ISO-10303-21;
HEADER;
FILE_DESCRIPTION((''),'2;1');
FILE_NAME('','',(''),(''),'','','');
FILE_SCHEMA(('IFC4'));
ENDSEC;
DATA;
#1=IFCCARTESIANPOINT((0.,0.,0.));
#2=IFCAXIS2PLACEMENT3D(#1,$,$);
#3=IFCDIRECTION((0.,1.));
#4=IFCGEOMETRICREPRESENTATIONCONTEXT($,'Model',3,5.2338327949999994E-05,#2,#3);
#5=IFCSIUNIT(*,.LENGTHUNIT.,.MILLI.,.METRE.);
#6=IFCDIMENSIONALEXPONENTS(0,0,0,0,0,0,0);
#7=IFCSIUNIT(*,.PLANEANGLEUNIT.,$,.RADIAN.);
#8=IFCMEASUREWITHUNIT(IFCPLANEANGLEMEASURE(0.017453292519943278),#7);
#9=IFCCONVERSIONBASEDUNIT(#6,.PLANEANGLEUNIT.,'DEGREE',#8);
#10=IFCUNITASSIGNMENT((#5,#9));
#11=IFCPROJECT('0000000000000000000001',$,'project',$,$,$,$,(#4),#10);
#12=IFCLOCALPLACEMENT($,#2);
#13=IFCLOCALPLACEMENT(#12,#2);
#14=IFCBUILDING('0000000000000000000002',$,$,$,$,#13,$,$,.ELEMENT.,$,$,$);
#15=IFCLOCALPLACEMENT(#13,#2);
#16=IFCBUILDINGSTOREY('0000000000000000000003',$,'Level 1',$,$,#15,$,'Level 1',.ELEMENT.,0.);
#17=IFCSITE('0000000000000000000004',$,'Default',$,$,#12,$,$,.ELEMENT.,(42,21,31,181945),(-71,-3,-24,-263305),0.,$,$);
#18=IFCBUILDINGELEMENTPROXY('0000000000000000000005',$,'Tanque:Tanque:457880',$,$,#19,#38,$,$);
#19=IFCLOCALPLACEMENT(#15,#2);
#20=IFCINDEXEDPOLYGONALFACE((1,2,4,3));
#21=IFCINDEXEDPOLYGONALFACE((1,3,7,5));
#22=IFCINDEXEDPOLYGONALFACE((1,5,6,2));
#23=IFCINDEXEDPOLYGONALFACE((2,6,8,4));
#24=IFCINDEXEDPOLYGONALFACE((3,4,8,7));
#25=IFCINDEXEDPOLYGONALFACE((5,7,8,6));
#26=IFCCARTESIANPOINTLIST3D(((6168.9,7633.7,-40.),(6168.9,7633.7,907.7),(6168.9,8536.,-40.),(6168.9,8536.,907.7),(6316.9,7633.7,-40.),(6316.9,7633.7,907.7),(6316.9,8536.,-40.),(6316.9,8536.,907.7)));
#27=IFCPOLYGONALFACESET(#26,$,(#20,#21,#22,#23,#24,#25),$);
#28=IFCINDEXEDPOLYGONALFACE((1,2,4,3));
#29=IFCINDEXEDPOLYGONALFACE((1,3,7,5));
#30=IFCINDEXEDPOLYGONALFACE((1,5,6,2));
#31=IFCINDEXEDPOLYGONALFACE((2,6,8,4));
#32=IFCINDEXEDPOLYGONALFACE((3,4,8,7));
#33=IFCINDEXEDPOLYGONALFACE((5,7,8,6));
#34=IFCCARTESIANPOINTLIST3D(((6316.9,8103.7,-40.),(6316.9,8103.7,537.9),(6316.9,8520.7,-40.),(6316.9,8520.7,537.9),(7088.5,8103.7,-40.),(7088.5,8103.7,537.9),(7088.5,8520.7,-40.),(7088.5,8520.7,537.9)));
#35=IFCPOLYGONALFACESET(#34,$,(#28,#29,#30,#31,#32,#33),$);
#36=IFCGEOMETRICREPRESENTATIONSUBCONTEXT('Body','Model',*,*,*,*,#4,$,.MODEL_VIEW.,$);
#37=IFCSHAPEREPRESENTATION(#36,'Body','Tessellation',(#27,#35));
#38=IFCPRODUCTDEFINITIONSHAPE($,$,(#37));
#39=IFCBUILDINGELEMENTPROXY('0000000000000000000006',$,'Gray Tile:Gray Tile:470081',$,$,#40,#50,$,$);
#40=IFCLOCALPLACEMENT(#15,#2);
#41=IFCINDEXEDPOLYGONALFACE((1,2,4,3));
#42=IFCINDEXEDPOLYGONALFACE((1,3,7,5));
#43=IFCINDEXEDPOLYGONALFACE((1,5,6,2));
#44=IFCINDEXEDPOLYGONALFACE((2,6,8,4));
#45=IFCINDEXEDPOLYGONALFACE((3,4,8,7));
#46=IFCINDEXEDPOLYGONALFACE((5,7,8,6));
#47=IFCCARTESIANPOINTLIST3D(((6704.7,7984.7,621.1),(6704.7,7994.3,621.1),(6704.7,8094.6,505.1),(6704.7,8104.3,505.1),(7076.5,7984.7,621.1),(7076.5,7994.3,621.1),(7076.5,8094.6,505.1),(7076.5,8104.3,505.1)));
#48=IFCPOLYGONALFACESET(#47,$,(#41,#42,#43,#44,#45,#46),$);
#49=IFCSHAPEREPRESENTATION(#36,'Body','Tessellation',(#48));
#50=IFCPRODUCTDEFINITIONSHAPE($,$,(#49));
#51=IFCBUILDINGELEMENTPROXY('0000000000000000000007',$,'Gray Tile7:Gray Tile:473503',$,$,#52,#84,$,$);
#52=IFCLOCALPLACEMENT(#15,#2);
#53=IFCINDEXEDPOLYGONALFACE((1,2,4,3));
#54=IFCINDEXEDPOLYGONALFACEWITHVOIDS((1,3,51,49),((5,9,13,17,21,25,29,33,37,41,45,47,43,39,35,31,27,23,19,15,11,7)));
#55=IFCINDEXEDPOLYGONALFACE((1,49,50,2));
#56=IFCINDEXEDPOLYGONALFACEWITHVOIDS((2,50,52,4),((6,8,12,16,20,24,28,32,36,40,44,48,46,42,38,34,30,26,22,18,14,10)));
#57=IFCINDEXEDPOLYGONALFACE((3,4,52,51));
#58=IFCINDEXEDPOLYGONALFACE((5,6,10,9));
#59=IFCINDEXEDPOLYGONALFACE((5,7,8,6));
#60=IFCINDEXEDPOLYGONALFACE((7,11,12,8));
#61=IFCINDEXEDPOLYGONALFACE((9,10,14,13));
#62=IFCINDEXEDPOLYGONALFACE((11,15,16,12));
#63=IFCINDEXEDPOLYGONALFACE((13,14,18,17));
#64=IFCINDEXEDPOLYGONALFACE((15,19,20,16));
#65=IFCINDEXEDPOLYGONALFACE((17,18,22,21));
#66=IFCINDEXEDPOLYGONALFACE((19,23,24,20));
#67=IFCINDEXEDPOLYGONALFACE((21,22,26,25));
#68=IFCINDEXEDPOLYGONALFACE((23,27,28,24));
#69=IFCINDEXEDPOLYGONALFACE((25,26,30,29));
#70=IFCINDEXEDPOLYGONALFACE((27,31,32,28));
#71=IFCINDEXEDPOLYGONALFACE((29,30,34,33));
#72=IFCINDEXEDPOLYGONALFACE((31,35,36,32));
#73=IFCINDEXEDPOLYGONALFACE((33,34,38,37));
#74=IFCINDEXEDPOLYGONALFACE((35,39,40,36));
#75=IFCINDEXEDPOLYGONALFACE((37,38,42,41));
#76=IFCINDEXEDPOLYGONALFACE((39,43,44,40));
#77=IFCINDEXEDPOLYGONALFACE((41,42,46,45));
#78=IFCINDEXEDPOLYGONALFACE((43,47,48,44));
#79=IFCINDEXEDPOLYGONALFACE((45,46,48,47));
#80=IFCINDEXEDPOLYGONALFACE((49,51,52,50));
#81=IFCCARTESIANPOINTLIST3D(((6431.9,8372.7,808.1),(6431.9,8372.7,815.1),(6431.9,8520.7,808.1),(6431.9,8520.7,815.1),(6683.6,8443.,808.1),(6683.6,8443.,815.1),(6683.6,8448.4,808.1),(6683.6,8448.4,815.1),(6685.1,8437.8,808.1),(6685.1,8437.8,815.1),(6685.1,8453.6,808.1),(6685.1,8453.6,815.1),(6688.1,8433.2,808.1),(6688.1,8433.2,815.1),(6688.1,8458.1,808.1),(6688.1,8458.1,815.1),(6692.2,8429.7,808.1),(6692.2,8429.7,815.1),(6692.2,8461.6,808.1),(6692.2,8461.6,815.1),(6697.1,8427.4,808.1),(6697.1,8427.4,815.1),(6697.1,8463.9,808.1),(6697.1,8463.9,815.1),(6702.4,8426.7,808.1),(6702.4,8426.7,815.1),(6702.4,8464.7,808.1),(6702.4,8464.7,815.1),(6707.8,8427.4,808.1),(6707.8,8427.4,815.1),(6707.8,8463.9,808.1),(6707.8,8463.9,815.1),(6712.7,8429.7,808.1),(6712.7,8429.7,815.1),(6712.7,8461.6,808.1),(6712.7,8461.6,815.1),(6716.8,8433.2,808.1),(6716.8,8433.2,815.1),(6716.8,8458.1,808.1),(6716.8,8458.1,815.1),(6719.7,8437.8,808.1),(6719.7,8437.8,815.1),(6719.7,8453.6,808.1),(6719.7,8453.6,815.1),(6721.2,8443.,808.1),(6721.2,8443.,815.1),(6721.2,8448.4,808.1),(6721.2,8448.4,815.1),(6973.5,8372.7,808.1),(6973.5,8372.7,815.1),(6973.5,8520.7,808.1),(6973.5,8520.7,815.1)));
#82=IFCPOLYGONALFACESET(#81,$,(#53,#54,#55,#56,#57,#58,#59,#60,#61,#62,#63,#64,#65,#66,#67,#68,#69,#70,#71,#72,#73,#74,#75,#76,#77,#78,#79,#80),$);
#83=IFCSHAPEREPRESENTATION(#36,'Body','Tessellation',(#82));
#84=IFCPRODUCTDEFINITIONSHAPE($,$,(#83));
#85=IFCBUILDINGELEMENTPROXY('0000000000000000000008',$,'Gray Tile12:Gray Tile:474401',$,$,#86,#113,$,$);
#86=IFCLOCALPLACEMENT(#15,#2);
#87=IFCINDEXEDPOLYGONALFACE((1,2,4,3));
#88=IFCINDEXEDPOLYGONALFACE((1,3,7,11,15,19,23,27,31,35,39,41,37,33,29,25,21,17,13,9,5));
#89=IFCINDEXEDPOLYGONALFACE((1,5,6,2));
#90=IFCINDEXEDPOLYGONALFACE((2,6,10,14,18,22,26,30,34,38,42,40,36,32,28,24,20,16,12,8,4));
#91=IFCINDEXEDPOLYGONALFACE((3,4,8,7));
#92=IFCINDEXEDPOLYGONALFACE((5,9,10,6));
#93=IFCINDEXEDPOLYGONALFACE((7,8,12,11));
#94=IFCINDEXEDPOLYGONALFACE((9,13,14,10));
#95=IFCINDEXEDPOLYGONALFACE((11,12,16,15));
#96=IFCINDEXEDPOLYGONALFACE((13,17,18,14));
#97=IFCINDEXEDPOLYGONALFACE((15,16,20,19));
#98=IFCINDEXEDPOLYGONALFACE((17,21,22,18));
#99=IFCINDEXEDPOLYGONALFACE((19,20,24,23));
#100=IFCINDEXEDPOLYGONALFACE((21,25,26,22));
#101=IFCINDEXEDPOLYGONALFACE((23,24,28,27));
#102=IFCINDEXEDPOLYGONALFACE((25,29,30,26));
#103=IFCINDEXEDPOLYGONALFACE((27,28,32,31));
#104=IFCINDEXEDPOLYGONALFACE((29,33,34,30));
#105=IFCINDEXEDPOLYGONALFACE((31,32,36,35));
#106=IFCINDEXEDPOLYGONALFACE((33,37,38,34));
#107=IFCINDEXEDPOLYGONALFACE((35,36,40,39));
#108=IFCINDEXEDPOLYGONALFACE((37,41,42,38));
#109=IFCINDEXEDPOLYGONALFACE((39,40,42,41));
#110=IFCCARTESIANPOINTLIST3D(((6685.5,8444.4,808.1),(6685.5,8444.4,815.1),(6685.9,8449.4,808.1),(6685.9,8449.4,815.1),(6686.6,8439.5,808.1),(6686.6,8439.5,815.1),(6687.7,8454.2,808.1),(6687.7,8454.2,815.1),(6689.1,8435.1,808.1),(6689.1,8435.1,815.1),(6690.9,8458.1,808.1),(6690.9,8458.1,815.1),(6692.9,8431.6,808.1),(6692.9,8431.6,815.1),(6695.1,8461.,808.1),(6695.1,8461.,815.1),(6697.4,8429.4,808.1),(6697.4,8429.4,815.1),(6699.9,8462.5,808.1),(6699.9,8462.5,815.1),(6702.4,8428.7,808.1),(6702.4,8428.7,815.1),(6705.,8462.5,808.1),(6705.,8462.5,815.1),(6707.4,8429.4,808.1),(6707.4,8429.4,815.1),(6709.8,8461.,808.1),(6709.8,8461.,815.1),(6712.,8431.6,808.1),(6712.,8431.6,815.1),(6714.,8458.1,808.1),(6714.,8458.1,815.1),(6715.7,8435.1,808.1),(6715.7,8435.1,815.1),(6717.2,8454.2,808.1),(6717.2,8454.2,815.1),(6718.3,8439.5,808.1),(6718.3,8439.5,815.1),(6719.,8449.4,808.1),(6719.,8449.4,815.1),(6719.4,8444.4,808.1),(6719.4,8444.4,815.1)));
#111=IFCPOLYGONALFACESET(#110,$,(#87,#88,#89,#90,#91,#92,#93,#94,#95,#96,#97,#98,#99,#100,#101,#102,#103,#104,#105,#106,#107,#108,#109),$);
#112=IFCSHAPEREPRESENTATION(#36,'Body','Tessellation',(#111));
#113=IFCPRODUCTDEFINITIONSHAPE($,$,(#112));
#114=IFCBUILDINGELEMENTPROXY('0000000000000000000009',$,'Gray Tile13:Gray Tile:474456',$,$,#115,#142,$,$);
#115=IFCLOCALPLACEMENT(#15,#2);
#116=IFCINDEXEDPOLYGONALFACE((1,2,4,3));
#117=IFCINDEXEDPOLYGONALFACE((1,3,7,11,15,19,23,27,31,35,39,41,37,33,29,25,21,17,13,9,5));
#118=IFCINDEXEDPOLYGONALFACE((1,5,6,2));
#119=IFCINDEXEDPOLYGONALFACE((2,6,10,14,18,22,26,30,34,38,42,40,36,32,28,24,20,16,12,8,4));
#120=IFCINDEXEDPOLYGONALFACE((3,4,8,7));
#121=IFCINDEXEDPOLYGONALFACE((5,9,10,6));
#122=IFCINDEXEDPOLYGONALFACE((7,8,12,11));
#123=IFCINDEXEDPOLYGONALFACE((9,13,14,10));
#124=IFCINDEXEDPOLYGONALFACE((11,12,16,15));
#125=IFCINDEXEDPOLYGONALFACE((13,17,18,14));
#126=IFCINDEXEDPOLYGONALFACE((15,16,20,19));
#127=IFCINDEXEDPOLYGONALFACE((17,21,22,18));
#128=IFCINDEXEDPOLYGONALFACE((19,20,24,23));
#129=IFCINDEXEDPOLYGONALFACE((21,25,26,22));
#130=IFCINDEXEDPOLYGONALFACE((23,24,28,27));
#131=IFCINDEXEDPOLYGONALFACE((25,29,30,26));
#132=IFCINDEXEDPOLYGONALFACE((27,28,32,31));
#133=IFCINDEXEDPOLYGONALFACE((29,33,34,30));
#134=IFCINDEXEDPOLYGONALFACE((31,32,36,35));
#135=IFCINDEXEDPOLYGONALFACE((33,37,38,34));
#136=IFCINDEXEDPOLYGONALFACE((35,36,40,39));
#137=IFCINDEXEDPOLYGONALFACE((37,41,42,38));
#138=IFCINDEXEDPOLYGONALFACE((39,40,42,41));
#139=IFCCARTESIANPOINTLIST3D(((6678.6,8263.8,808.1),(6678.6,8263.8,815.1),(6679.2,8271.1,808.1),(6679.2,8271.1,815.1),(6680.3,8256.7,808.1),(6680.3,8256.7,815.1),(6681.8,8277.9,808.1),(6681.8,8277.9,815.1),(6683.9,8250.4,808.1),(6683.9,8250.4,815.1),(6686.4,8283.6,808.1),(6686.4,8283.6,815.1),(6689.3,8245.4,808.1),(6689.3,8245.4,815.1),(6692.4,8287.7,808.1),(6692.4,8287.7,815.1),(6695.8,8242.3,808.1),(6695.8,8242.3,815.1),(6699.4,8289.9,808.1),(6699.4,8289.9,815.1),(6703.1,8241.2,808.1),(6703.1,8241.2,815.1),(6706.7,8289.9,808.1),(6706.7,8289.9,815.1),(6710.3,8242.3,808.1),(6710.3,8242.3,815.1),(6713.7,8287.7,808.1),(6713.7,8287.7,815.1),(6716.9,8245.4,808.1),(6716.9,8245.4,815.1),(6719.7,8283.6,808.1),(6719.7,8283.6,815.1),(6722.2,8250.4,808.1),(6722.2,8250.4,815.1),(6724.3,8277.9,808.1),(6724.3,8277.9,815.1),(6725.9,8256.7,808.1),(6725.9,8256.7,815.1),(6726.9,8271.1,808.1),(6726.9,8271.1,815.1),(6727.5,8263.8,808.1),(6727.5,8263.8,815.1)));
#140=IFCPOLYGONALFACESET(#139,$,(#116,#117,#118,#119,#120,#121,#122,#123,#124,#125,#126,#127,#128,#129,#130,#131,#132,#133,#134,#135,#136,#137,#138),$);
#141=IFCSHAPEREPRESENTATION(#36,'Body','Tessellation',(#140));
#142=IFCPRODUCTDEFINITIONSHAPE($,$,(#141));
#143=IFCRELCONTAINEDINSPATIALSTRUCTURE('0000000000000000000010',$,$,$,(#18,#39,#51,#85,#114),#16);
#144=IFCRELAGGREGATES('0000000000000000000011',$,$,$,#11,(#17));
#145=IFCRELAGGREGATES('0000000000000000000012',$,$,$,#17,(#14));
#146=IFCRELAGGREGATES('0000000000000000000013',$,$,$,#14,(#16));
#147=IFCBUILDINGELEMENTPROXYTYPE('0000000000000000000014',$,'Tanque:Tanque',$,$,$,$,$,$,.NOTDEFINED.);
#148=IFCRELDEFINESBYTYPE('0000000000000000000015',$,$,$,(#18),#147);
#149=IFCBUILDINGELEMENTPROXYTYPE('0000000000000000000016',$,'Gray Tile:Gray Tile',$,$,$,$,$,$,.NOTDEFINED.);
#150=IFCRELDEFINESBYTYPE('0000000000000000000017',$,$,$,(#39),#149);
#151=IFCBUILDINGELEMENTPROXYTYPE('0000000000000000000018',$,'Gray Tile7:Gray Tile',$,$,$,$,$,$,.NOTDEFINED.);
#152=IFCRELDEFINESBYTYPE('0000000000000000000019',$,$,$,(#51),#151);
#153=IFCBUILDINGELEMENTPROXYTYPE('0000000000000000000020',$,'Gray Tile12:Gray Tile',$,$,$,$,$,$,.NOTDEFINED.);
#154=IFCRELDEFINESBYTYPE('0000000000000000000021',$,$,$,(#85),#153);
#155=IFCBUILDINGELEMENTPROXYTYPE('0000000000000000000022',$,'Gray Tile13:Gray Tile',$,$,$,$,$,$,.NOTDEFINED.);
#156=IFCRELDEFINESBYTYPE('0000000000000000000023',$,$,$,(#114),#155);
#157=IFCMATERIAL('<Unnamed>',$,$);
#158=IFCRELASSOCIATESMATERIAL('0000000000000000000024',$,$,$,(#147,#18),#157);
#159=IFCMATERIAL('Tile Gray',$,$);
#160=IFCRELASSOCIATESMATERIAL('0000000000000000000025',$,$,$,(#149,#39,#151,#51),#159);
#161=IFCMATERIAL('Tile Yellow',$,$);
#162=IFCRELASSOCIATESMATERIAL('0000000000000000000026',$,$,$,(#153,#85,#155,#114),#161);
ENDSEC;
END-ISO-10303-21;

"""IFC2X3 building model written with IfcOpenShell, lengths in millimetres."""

from ifc_helpers import new_model, entity, si_unit, converted_unit, direction, frame, frame_2d, origin, origin_2d_with_axis, place, context, subcontext, project, spatial, polyline, circle_curve, parameter, trimmed, segment, composite_curve, rectangle, circle, outline, extrude, source, transform, mapped, material, type_object, type_shapes, element, save


model = new_model("IFC2X3")

# Units and contexts
model_context = context("Model", 3, precision=5.2338327949999994e-05, world=origin(), true_north=direction((0.0, 1.0)))
body_context = subcontext(model_context, "Body", "Model", "MODEL_VIEW")
ifc_project = project(units=[si_unit("LENGTHUNIT", "METRE", prefix="MILLI"), converted_unit("PLANEANGLEUNIT", "DEGREE", entity("IfcPlaneAngleMeasure", 0.017453292519943278), si_unit("PLANEANGLEUNIT", "RADIAN"), dimensions=[0, 0, 0, 0, 0, 0, 0])], contexts=[model_context])

# Site, building, storey
site_placement = place(None, origin())
site = spatial("IfcSite", under=ifc_project, at=site_placement, Name="Default", CompositionType="ELEMENT", RefLatitude=(42, 21, 31, 181945), RefLongitude=(-71, -3, -24, -263305), RefElevation=0.0)
building_placement = place(site_placement, origin())
building = spatial("IfcBuilding", under=site, at=building_placement, CompositionType="ELEMENT")
storey_placement = place(building_placement, origin())
storey = spatial("IfcBuildingStorey", under=building, at=storey_placement, Name="Level 1", LongName="Level 1", CompositionType="ELEMENT", Elevation=0.0)

# Building element proxies
ifc_material_1 = material(Name="<Unnamed>")
building_element_proxy_type_1 = type_object("IfcBuildingElementProxyType", Name="Tanque:Tanque", PredefinedType="NOTDEFINED", material=ifc_material_1)
shared_shape_1 = source(origin(), body_context, "Body", "SweptSolid", [
    extrude(rectangle(XDim=902.4, YDim=148.0, at=frame_2d((0.0, 0.0), x_axis=(1.0, 0.0))), frame((6242.9, 8084.8, -40.0), z_axis=(0.0, 0.0, 1.0), x_axis=(0.0, -1.0, 0.0)), (0.0, 0.0, 1.0), 947.7),
    extrude(rectangle(XDim=417.0, YDim=771.6, at=frame_2d((0.0, 0.0), x_axis=(1.0, 0.0))), frame((6702.7, 8312.2, -40.0), z_axis=(0.0, 0.0, 1.0), x_axis=(0.0, -1.0, 0.0)), (0.0, 0.0, 1.0), 577.9),
])
type_shapes(building_element_proxy_type_1, [shared_shape_1])
proxy_1_placement = place(storey_placement, origin())
element("IfcBuildingElementProxy", 1, at=proxy_1_placement, inside=storey, type_object=building_element_proxy_type_1, material=ifc_material_1, Name="Tanque:Tanque:457880", context=body_context, shape_type="MappedRepresentation", body=[
    mapped(shared_shape_1, transform((0.0, 0.0, 0.0), scale=1.0)),
])
ifc_material_2 = material(Name="Tile Gray")
building_element_proxy_type_2 = type_object("IfcBuildingElementProxyType", Name="Gray Tile:Gray Tile", PredefinedType="NOTDEFINED", material=ifc_material_2)
shared_shape_2 = source(origin(), body_context, "Body", "SweptSolid", [
    extrude(outline(polyline([(-83.2, -3.5), (76.6, -3.5), (83.2, 3.5), (-76.6, 3.5), (-83.2, -3.5)])), frame((6704.7, 8044.5, 550.1), z_axis=(1.0, 0.0, 0.0), x_axis=(0.0, -0.688092, 0.725624)), (0.0, 0.0, 1.0), 371.8),
])
type_shapes(building_element_proxy_type_2, [shared_shape_2])
proxy_2_placement = place(storey_placement, frame((0.0, 0.0, 13.0)))
element("IfcBuildingElementProxy", 2, at=proxy_2_placement, inside=storey, type_object=building_element_proxy_type_2, material=ifc_material_2, Name="Gray Tile:Gray Tile:470081", context=body_context, shape_type="MappedRepresentation", body=[
    mapped(shared_shape_2, transform((0.0, 0.0, 0.0), scale=1.0)),
])
building_element_proxy_type_3 = type_object("IfcBuildingElementProxyType", Name="Gray Tile7:Gray Tile", PredefinedType="NOTDEFINED", material=ifc_material_2)
shared_shape_3 = source(origin(), body_context, "Body", "SweptSolid", [
    extrude(outline(polyline([(-74.0, -270.8), (74.0, -270.8), (74.0, 270.8), (-74.0, 270.8), (-74.0, -270.8)]), holes=[composite_curve([segment(trimmed(circle_curve(frame_2d((-1.0, 0.3), x_axis=(-1.0, 0.0)), 19.0), [parameter(0.0)], [parameter(180.0)], True, "PARAMETER"), False, "CONTINUOUS"), segment(trimmed(circle_curve(frame_2d((-1.0, 0.3), x_axis=(-1.0, 0.0)), 19.0), [parameter(180.0)], [parameter(0.0)], True, "PARAMETER"), False, "CONTINUOUS")], self_intersect=False)]), frame((6702.7, 8446.7, 808.1), z_axis=(0.0, 0.0, 1.0), x_axis=(0.0, 1.0, 0.0)), (0.0, 0.0, 1.0), 7.0),
])
type_shapes(building_element_proxy_type_3, [shared_shape_3])
proxy_3_placement = place(storey_placement, origin())
element("IfcBuildingElementProxy", 3, at=proxy_3_placement, inside=storey, type_object=building_element_proxy_type_3, material=ifc_material_2, Name="Gray Tile7:Gray Tile:473503", context=body_context, shape_type="MappedRepresentation", body=[
    mapped(shared_shape_3, transform((0.0, 0.0, 0.0), scale=1.0)),
])
ifc_material_3 = material(Name="Tile Yellow")
building_element_proxy_type_4 = type_object("IfcBuildingElementProxyType", Name="Gray Tile12:Gray Tile", PredefinedType="NOTDEFINED", material=ifc_material_3)
shared_shape_4 = source(origin(), body_context, "Body", "SweptSolid", [
    extrude(circle(Radius=17.0, at=origin_2d_with_axis()), frame((6702.4, 8445.7, 808.1), z_axis=(0.0, 0.0, 1.0), x_axis=(0.0, -1.0, 0.0)), (0.0, 0.0, 1.0), 7.0),
])
type_shapes(building_element_proxy_type_4, [shared_shape_4])
proxy_4_placement = place(storey_placement, origin())
element("IfcBuildingElementProxy", 4, at=proxy_4_placement, inside=storey, type_object=building_element_proxy_type_4, material=ifc_material_3, Name="Gray Tile12:Gray Tile:474401", context=body_context, shape_type="MappedRepresentation", body=[
    mapped(shared_shape_4, transform((0.0, 0.0, 0.0), scale=1.0)),
])
building_element_proxy_type_5 = type_object("IfcBuildingElementProxyType", Name="Gray Tile13:Gray Tile", PredefinedType="NOTDEFINED", material=ifc_material_3)
shared_shape_5 = source(origin(), body_context, "Body", "SweptSolid", [
    extrude(circle(Radius=24.5, at=origin_2d_with_axis()), frame((6703.1, 8265.7, 808.1), z_axis=(0.0, 0.0, 1.0), x_axis=(0.0, -1.0, 0.0)), (0.0, 0.0, 1.0), 7.0),
])
type_shapes(building_element_proxy_type_5, [shared_shape_5])
proxy_5_placement = place(storey_placement, origin())
element("IfcBuildingElementProxy", 5, at=proxy_5_placement, inside=storey, type_object=building_element_proxy_type_5, material=ifc_material_3, Name="Gray Tile13:Gray Tile:474456", context=body_context, shape_type="MappedRepresentation", body=[
    mapped(shared_shape_5, transform((0.0, 0.0, 0.0), scale=1.0)),
])

save(model, "model.ifc")
